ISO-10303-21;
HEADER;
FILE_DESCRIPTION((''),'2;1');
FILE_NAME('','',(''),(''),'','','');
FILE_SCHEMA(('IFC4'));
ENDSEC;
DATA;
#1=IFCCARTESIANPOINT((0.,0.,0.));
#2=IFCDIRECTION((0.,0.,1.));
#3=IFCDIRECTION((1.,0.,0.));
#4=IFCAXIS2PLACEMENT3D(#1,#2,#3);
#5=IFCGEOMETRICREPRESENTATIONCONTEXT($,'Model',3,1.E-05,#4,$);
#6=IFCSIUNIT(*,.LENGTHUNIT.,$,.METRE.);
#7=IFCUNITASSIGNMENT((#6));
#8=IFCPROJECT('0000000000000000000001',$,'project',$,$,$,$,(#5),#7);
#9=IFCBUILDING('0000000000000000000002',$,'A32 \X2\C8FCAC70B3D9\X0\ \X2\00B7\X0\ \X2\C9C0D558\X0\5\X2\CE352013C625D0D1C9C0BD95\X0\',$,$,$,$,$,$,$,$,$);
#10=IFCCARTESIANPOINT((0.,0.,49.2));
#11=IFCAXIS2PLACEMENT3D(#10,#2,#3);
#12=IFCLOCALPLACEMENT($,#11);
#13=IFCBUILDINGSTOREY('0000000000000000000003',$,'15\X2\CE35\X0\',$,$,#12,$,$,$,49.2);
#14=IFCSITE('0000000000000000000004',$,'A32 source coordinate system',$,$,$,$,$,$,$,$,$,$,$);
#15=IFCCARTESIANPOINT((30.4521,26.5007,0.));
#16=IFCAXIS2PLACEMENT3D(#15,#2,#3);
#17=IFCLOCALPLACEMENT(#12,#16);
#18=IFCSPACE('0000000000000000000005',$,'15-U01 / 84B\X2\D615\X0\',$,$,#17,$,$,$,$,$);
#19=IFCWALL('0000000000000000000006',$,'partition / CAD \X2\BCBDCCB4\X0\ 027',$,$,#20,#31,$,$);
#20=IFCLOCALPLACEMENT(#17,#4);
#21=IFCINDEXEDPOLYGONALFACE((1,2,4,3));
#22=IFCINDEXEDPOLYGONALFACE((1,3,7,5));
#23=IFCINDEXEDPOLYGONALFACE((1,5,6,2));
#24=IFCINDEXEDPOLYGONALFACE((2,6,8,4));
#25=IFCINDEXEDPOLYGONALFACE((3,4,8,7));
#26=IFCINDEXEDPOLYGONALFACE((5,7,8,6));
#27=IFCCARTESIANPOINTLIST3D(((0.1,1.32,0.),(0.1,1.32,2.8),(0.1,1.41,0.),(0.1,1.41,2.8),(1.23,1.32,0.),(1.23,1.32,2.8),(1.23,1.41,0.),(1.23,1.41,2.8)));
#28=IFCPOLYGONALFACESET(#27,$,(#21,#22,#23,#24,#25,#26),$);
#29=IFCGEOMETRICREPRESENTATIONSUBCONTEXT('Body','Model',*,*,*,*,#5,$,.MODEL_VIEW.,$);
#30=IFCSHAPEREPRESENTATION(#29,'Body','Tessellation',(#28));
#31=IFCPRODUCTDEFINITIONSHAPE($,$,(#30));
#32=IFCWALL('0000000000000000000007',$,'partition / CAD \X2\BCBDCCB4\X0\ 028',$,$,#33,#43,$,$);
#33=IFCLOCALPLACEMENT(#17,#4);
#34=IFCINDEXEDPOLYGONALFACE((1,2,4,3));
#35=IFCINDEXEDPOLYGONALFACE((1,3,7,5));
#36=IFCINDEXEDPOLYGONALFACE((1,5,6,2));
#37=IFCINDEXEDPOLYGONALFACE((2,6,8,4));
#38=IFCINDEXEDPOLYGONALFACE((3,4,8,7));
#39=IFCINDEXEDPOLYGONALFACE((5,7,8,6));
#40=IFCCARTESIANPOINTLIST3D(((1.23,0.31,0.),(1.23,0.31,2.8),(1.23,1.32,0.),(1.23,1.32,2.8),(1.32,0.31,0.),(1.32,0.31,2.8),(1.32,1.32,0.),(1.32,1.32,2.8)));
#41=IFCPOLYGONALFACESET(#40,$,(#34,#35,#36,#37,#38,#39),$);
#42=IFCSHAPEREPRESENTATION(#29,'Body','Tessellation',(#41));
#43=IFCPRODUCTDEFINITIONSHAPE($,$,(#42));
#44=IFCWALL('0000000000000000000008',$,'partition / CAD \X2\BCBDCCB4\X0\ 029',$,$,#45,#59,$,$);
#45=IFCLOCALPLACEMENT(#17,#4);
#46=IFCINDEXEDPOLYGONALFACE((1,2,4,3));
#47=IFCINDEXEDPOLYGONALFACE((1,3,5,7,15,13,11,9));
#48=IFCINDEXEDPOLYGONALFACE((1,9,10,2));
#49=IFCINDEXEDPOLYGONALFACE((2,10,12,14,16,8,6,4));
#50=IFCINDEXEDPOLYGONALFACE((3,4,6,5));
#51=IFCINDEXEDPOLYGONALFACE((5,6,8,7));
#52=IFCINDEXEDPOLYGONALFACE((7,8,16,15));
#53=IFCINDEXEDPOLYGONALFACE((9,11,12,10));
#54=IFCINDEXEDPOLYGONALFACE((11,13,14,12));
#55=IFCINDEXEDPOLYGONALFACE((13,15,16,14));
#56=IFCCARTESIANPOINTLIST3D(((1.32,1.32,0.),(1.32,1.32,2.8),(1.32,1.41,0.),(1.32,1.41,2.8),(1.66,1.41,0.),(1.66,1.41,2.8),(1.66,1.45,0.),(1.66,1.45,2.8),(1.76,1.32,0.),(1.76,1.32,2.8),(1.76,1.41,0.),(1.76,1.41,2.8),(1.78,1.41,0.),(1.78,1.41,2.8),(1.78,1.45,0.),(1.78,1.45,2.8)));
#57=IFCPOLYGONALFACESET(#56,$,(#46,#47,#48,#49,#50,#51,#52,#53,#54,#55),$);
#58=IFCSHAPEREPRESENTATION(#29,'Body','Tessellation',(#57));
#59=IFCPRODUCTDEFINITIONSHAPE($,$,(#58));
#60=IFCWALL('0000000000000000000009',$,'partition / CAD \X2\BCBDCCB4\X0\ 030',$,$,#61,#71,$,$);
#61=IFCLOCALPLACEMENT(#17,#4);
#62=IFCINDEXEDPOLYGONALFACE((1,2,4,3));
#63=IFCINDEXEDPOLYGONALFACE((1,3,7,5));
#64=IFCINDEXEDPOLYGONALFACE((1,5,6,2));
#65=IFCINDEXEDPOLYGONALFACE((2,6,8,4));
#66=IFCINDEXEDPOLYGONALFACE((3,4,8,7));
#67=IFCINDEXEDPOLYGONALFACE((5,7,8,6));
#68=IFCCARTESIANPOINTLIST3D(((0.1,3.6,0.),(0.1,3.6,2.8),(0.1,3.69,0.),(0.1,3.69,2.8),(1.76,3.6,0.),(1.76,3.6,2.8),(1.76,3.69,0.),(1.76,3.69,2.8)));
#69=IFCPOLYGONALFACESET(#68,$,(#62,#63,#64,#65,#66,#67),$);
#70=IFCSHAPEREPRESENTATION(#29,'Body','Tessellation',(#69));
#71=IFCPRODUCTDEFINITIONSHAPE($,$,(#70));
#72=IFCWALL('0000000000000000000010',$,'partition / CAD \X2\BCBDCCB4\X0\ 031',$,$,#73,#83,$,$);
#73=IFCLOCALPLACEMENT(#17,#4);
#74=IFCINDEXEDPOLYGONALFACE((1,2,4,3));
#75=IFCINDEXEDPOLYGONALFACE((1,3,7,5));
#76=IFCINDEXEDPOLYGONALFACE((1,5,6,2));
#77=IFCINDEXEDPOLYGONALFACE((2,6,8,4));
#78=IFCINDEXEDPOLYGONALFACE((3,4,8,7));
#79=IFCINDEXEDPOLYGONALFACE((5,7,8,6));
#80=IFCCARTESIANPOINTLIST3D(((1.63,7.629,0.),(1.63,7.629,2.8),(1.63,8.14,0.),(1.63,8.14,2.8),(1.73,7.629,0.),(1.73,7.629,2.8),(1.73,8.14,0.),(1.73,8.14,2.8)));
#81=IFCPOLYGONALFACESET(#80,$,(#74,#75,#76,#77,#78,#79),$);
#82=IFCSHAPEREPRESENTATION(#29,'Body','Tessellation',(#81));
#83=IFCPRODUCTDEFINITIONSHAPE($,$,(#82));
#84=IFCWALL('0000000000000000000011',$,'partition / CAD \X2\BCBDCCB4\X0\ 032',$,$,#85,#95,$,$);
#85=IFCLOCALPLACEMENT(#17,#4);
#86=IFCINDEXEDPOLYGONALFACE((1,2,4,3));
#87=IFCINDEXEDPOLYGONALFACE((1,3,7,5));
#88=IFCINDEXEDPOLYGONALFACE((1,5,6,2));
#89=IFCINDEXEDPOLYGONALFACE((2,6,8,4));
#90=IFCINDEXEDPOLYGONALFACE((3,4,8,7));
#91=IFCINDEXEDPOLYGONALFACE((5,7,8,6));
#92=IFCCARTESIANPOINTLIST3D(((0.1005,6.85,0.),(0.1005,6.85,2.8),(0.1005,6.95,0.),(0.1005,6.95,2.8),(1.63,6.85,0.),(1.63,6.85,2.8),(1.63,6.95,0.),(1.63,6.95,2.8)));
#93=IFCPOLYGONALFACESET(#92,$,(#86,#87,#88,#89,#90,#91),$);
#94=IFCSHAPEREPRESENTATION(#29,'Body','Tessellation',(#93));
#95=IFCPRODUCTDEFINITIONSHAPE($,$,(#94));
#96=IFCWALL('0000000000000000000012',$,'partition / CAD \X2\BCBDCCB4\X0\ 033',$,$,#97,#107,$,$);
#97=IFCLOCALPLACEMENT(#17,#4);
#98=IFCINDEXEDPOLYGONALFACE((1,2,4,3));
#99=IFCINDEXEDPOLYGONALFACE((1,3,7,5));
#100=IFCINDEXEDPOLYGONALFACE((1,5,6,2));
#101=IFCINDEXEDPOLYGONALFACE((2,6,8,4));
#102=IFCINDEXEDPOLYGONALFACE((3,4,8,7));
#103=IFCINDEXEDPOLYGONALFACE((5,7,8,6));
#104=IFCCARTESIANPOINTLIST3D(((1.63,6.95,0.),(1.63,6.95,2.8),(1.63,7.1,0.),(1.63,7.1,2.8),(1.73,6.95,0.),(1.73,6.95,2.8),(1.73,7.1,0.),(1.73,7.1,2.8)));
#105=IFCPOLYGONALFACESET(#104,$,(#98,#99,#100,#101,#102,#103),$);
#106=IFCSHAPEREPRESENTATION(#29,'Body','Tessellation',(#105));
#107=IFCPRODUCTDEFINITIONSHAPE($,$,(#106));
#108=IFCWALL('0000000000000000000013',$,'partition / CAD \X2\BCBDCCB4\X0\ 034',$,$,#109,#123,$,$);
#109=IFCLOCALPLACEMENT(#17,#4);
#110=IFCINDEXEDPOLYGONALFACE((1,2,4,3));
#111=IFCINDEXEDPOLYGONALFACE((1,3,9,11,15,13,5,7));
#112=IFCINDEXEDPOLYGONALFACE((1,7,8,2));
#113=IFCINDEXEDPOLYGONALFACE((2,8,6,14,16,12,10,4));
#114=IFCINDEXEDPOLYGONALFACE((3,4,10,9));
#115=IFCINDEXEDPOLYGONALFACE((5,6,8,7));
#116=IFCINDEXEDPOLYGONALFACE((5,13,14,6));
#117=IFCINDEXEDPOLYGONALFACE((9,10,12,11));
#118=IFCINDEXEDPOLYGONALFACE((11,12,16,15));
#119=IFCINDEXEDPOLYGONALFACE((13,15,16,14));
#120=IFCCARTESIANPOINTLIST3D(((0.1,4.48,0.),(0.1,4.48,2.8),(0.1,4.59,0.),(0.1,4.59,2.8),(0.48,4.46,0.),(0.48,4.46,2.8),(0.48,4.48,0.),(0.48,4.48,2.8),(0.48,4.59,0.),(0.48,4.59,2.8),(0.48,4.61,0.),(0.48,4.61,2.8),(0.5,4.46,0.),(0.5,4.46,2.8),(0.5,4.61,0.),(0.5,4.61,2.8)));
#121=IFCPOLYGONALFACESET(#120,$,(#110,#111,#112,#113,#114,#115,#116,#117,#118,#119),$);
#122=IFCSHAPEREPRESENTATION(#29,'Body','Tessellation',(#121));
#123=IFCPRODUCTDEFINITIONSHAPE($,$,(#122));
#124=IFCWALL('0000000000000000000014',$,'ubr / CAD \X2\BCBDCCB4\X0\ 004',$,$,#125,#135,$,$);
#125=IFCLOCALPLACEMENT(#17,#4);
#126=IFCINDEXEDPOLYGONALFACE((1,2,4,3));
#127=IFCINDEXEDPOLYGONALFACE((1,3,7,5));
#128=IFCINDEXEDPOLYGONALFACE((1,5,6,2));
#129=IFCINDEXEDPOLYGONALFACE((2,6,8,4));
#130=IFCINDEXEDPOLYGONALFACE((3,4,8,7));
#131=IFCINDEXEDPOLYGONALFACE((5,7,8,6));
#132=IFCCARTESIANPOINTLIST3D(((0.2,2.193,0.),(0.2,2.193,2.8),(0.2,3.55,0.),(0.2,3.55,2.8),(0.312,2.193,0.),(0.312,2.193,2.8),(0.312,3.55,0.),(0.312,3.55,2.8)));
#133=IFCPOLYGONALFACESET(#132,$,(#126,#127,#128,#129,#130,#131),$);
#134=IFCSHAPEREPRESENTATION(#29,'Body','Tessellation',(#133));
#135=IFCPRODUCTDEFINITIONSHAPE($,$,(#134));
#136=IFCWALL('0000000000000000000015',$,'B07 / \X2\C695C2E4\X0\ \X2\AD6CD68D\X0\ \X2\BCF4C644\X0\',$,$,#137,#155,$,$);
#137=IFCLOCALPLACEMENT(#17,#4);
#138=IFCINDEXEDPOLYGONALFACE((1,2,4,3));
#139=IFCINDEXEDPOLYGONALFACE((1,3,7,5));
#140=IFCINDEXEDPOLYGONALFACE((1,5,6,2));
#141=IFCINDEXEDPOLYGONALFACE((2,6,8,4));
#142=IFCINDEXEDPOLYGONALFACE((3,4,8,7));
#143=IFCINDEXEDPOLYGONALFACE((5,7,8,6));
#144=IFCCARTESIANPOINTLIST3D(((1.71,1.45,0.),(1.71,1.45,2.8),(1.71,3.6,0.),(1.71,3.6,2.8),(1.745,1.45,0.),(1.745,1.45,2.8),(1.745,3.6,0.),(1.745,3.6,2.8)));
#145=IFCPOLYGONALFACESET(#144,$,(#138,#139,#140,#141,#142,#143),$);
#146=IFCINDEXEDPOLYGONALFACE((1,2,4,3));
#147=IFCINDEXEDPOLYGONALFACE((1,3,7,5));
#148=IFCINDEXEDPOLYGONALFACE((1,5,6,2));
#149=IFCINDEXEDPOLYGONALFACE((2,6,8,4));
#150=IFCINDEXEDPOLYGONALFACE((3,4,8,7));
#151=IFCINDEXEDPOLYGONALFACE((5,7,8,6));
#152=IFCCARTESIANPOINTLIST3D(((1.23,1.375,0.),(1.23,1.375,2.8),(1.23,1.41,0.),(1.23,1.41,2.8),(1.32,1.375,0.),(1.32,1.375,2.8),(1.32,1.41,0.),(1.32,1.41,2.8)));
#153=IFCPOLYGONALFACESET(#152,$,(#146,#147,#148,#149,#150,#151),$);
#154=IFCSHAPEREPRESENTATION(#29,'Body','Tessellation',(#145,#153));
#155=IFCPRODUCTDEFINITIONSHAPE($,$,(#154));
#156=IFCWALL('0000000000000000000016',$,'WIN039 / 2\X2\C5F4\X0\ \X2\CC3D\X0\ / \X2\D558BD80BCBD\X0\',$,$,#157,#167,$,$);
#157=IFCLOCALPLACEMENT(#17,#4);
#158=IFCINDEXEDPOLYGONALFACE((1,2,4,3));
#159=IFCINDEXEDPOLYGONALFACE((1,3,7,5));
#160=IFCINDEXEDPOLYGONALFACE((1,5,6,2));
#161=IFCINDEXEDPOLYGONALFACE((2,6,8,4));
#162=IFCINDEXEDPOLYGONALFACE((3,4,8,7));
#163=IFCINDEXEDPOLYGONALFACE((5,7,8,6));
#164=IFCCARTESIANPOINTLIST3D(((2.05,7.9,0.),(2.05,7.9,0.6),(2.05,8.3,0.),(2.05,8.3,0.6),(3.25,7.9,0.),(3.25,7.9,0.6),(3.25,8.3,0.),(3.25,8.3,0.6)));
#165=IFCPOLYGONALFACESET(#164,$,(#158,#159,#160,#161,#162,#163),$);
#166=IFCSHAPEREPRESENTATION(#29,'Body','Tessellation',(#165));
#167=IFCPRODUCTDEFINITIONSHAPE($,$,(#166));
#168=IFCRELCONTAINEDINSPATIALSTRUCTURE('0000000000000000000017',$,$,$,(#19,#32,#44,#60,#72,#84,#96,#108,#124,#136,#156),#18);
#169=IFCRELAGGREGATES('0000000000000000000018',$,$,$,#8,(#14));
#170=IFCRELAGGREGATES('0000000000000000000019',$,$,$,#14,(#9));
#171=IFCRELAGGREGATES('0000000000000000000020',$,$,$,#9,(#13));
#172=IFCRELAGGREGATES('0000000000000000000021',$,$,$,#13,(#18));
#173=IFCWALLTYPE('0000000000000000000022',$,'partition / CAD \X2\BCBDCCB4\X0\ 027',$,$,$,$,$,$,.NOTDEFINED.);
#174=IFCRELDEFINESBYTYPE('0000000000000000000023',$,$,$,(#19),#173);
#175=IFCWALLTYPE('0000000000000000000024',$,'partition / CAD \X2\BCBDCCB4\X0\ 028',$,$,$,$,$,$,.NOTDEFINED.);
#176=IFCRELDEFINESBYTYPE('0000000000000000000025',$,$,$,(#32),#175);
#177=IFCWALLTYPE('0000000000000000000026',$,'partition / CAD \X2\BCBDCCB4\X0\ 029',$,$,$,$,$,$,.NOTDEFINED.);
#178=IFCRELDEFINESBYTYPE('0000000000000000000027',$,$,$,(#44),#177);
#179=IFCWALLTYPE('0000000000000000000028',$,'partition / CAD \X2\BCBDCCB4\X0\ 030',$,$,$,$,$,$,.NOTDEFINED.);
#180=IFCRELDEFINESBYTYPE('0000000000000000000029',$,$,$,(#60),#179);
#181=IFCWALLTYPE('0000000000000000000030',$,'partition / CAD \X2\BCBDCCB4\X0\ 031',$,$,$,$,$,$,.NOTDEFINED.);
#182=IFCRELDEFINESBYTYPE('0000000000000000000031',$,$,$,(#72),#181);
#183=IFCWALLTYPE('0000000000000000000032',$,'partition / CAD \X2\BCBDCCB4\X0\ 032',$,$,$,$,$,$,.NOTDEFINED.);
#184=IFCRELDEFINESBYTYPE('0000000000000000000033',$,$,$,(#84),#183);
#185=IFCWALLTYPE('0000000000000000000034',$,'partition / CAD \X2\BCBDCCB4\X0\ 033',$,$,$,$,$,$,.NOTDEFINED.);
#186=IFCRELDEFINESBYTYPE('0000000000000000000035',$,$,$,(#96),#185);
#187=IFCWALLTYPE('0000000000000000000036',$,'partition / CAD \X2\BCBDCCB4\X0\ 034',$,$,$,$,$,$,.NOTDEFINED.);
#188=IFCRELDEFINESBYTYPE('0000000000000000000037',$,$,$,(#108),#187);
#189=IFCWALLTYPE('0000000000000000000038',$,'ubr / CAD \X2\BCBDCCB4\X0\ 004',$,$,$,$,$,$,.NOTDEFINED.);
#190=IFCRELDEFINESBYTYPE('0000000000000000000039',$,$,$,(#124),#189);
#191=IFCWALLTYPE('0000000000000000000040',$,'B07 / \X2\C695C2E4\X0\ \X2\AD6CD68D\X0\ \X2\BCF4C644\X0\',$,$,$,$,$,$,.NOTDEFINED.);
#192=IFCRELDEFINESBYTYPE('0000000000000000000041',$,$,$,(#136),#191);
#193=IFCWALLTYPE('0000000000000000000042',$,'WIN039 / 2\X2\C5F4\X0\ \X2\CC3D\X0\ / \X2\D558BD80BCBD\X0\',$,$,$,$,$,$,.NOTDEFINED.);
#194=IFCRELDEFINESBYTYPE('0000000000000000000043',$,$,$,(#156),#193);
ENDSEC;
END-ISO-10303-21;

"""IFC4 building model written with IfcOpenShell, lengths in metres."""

from ifc_helpers import new_model, si_unit, frame, origin, origin_with_axes, place, context, subcontext, project, spatial, polyline, outline, extrude, source, transform, mapped, type_object, type_shapes, element, save


model = new_model("IFC4")

# Units and contexts
model_context = context("Model", 3, precision=1e-05, world=origin_with_axes())
body_context = subcontext(model_context, "Body", "Model", "MODEL_VIEW")
ifc_project = project(units=[si_unit("LENGTHUNIT", "METRE")], contexts=[model_context])

# Site, building, storey, space
site = spatial("IfcSite", under=ifc_project, Name="A32 source coordinate system")
building = spatial("IfcBuilding", under=site, Name="A32 주거동 · 지하5층–옥탑지붕")
storey_placement = place(None, frame((0.0, 0.0, 49.2), z_axis=(0.0, 0.0, 1.0), x_axis=(1.0, 0.0, 0.0)))
storey = spatial("IfcBuildingStorey", under=building, at=storey_placement, Name="15층", Elevation=49.2)
space_placement = place(storey_placement, frame((30.4521, 26.5007, 0.0), z_axis=(0.0, 0.0, 1.0), x_axis=(1.0, 0.0, 0.0)))
space = spatial("IfcSpace", under=storey, at=space_placement, Name="15-U01 / 84B형")

# Walls
wall_type_1 = type_object("IfcWallType", Name="partition / CAD 벽체 027", PredefinedType="NOTDEFINED")
shared_shape_1 = source(origin(), body_context, "Body", "SweptSolid", [
    extrude(outline(polyline([(0.1, 1.32), (0.1, 1.41), (1.23, 1.41), (1.23, 1.32), (0.1, 1.32)])), origin(), (0.0, 0.0, 1.0), 2.8),
])
type_shapes(wall_type_1, [shared_shape_1])
wall_1_placement = place(space_placement, origin_with_axes())
element("IfcWall", 1, at=wall_1_placement, inside=space, type_object=wall_type_1, Name="partition / CAD 벽체 027", context=body_context, shape_type="MappedRepresentation", body=[
    mapped(shared_shape_1, transform((0.0, 0.0, 0.0), scale=1.0)),
])
wall_type_2 = type_object("IfcWallType", Name="partition / CAD 벽체 028", PredefinedType="NOTDEFINED")
shared_shape_2 = source(origin(), body_context, "Body", "SweptSolid", [
    extrude(outline(polyline([(1.32, 0.31), (1.23, 0.31), (1.23, 1.32), (1.32, 1.32), (1.32, 0.31)])), origin(), (0.0, 0.0, 1.0), 2.8),
])
type_shapes(wall_type_2, [shared_shape_2])
wall_2_placement = place(space_placement, origin_with_axes())
element("IfcWall", 2, at=wall_2_placement, inside=space, type_object=wall_type_2, Name="partition / CAD 벽체 028", context=body_context, shape_type="MappedRepresentation", body=[
    mapped(shared_shape_2, transform((0.0, 0.0, 0.0), scale=1.0)),
])
wall_type_3 = type_object("IfcWallType", Name="partition / CAD 벽체 029", PredefinedType="NOTDEFINED")
shared_shape_3 = source(origin(), body_context, "Body", "SweptSolid", [
    extrude(outline(polyline([(1.66, 1.41), (1.66, 1.45), (1.78, 1.45), (1.78, 1.41), (1.76, 1.41), (1.76, 1.32), (1.32, 1.32), (1.32, 1.41), (1.66, 1.41)])), origin(), (0.0, 0.0, 1.0), 2.8),
])
type_shapes(wall_type_3, [shared_shape_3])
wall_3_placement = place(space_placement, origin_with_axes())
element("IfcWall", 3, at=wall_3_placement, inside=space, type_object=wall_type_3, Name="partition / CAD 벽체 029", context=body_context, shape_type="MappedRepresentation", body=[
    mapped(shared_shape_3, transform((0.0, 0.0, 0.0), scale=1.0)),
])
wall_type_4 = type_object("IfcWallType", Name="partition / CAD 벽체 030", PredefinedType="NOTDEFINED")
shared_shape_4 = source(origin(), body_context, "Body", "SweptSolid", [
    extrude(outline(polyline([(1.76, 3.69), (1.76, 3.6), (0.1, 3.6), (0.1, 3.69), (1.76, 3.69)])), origin(), (0.0, 0.0, 1.0), 2.8),
])
type_shapes(wall_type_4, [shared_shape_4])
wall_4_placement = place(space_placement, origin_with_axes())
element("IfcWall", 4, at=wall_4_placement, inside=space, type_object=wall_type_4, Name="partition / CAD 벽체 030", context=body_context, shape_type="MappedRepresentation", body=[
    mapped(shared_shape_4, transform((0.0, 0.0, 0.0), scale=1.0)),
])
wall_type_5 = type_object("IfcWallType", Name="partition / CAD 벽체 031", PredefinedType="NOTDEFINED")
shared_shape_5 = source(origin(), body_context, "Body", "SweptSolid", [
    extrude(outline(polyline([(1.63, 8.14), (1.73, 8.14), (1.73, 7.629), (1.63, 7.629), (1.63, 8.14)])), origin(), (0.0, 0.0, 1.0), 2.8),
])
type_shapes(wall_type_5, [shared_shape_5])
wall_5_placement = place(space_placement, origin_with_axes())
element("IfcWall", 5, at=wall_5_placement, inside=space, type_object=wall_type_5, Name="partition / CAD 벽체 031", context=body_context, shape_type="MappedRepresentation", body=[
    mapped(shared_shape_5, transform((0.0, 0.0, 0.0), scale=1.0)),
])
wall_type_6 = type_object("IfcWallType", Name="partition / CAD 벽체 032", PredefinedType="NOTDEFINED")
shared_shape_6 = source(origin(), body_context, "Body", "SweptSolid", [
    extrude(outline(polyline([(0.1005, 6.95), (1.63, 6.95), (1.63, 6.85), (0.1005, 6.85), (0.1005, 6.95)])), origin(), (0.0, 0.0, 1.0), 2.8),
])
type_shapes(wall_type_6, [shared_shape_6])
wall_6_placement = place(space_placement, origin_with_axes())
element("IfcWall", 6, at=wall_6_placement, inside=space, type_object=wall_type_6, Name="partition / CAD 벽체 032", context=body_context, shape_type="MappedRepresentation", body=[
    mapped(shared_shape_6, transform((0.0, 0.0, 0.0), scale=1.0)),
])
wall_type_7 = type_object("IfcWallType", Name="partition / CAD 벽체 033", PredefinedType="NOTDEFINED")
shared_shape_7 = source(origin(), body_context, "Body", "SweptSolid", [
    extrude(outline(polyline([(1.63, 7.1), (1.73, 7.1), (1.73, 6.95), (1.63, 6.95), (1.63, 7.1)])), origin(), (0.0, 0.0, 1.0), 2.8),
])
type_shapes(wall_type_7, [shared_shape_7])
wall_7_placement = place(space_placement, origin_with_axes())
element("IfcWall", 7, at=wall_7_placement, inside=space, type_object=wall_type_7, Name="partition / CAD 벽체 033", context=body_context, shape_type="MappedRepresentation", body=[
    mapped(shared_shape_7, transform((0.0, 0.0, 0.0), scale=1.0)),
])
wall_type_8 = type_object("IfcWallType", Name="partition / CAD 벽체 034", PredefinedType="NOTDEFINED")
shared_shape_8 = source(origin(), body_context, "Body", "SweptSolid", [
    extrude(outline(polyline([(0.48, 4.61), (0.5, 4.61), (0.5, 4.46), (0.48, 4.46), (0.48, 4.48), (0.1, 4.48), (0.1, 4.59), (0.48, 4.59), (0.48, 4.61)])), origin(), (0.0, 0.0, 1.0), 2.8),
])
type_shapes(wall_type_8, [shared_shape_8])
wall_8_placement = place(space_placement, origin_with_axes())
element("IfcWall", 8, at=wall_8_placement, inside=space, type_object=wall_type_8, Name="partition / CAD 벽체 034", context=body_context, shape_type="MappedRepresentation", body=[
    mapped(shared_shape_8, transform((0.0, 0.0, 0.0), scale=1.0)),
])
wall_type_9 = type_object("IfcWallType", Name="ubr / CAD 벽체 004", PredefinedType="NOTDEFINED")
shared_shape_9 = source(origin(), body_context, "Body", "SweptSolid", [
    extrude(outline(polyline([(0.312, 2.193), (0.2, 2.193), (0.2, 3.55), (0.312, 3.55), (0.312, 2.193)])), origin(), (0.0, 0.0, 1.0), 2.8),
])
type_shapes(wall_type_9, [shared_shape_9])
wall_9_placement = place(space_placement, origin_with_axes())
element("IfcWall", 9, at=wall_9_placement, inside=space, type_object=wall_type_9, Name="ubr / CAD 벽체 004", context=body_context, shape_type="MappedRepresentation", body=[
    mapped(shared_shape_9, transform((0.0, 0.0, 0.0), scale=1.0)),
])
wall_type_10 = type_object("IfcWallType", Name="B07 / 욕실 구획 보완", PredefinedType="NOTDEFINED")
shared_shape_10 = source(origin(), body_context, "Body", "SweptSolid", [
    extrude(outline(polyline([(1.71, 1.45), (1.71, 3.6), (1.745, 3.6), (1.745, 1.45), (1.71, 1.45)])), origin(), (0.0, 0.0, 1.0), 2.8),
    extrude(outline(polyline([(1.32, 1.41), (1.32, 1.375), (1.23, 1.375), (1.23, 1.41), (1.32, 1.41)])), origin(), (0.0, 0.0, 1.0), 2.8),
])
type_shapes(wall_type_10, [shared_shape_10])
wall_10_placement = place(space_placement, origin_with_axes())
element("IfcWall", 10, at=wall_10_placement, inside=space, type_object=wall_type_10, Name="B07 / 욕실 구획 보완", context=body_context, shape_type="MappedRepresentation", body=[
    mapped(shared_shape_10, transform((0.0, 0.0, 0.0), scale=1.0)),
])
wall_type_11 = type_object("IfcWallType", Name="WIN039 / 2열 창 / 하부벽", PredefinedType="NOTDEFINED")
shared_shape_11 = source(origin(), body_context, "Body", "SweptSolid", [
    extrude(outline(polyline([(2.05, 8.3), (3.25, 8.3), (3.25, 7.9), (2.05, 7.9), (2.05, 8.3)])), origin(), (0.0, 0.0, 1.0), 0.6),
])
type_shapes(wall_type_11, [shared_shape_11])
wall_11_placement = place(space_placement, origin_with_axes())
element("IfcWall", 11, at=wall_11_placement, inside=space, type_object=wall_type_11, Name="WIN039 / 2열 창 / 하부벽", context=body_context, shape_type="MappedRepresentation", body=[
    mapped(shared_shape_11, transform((0.0, 0.0, 0.0), scale=1.0)),
])

save(model, "model.ifc")
